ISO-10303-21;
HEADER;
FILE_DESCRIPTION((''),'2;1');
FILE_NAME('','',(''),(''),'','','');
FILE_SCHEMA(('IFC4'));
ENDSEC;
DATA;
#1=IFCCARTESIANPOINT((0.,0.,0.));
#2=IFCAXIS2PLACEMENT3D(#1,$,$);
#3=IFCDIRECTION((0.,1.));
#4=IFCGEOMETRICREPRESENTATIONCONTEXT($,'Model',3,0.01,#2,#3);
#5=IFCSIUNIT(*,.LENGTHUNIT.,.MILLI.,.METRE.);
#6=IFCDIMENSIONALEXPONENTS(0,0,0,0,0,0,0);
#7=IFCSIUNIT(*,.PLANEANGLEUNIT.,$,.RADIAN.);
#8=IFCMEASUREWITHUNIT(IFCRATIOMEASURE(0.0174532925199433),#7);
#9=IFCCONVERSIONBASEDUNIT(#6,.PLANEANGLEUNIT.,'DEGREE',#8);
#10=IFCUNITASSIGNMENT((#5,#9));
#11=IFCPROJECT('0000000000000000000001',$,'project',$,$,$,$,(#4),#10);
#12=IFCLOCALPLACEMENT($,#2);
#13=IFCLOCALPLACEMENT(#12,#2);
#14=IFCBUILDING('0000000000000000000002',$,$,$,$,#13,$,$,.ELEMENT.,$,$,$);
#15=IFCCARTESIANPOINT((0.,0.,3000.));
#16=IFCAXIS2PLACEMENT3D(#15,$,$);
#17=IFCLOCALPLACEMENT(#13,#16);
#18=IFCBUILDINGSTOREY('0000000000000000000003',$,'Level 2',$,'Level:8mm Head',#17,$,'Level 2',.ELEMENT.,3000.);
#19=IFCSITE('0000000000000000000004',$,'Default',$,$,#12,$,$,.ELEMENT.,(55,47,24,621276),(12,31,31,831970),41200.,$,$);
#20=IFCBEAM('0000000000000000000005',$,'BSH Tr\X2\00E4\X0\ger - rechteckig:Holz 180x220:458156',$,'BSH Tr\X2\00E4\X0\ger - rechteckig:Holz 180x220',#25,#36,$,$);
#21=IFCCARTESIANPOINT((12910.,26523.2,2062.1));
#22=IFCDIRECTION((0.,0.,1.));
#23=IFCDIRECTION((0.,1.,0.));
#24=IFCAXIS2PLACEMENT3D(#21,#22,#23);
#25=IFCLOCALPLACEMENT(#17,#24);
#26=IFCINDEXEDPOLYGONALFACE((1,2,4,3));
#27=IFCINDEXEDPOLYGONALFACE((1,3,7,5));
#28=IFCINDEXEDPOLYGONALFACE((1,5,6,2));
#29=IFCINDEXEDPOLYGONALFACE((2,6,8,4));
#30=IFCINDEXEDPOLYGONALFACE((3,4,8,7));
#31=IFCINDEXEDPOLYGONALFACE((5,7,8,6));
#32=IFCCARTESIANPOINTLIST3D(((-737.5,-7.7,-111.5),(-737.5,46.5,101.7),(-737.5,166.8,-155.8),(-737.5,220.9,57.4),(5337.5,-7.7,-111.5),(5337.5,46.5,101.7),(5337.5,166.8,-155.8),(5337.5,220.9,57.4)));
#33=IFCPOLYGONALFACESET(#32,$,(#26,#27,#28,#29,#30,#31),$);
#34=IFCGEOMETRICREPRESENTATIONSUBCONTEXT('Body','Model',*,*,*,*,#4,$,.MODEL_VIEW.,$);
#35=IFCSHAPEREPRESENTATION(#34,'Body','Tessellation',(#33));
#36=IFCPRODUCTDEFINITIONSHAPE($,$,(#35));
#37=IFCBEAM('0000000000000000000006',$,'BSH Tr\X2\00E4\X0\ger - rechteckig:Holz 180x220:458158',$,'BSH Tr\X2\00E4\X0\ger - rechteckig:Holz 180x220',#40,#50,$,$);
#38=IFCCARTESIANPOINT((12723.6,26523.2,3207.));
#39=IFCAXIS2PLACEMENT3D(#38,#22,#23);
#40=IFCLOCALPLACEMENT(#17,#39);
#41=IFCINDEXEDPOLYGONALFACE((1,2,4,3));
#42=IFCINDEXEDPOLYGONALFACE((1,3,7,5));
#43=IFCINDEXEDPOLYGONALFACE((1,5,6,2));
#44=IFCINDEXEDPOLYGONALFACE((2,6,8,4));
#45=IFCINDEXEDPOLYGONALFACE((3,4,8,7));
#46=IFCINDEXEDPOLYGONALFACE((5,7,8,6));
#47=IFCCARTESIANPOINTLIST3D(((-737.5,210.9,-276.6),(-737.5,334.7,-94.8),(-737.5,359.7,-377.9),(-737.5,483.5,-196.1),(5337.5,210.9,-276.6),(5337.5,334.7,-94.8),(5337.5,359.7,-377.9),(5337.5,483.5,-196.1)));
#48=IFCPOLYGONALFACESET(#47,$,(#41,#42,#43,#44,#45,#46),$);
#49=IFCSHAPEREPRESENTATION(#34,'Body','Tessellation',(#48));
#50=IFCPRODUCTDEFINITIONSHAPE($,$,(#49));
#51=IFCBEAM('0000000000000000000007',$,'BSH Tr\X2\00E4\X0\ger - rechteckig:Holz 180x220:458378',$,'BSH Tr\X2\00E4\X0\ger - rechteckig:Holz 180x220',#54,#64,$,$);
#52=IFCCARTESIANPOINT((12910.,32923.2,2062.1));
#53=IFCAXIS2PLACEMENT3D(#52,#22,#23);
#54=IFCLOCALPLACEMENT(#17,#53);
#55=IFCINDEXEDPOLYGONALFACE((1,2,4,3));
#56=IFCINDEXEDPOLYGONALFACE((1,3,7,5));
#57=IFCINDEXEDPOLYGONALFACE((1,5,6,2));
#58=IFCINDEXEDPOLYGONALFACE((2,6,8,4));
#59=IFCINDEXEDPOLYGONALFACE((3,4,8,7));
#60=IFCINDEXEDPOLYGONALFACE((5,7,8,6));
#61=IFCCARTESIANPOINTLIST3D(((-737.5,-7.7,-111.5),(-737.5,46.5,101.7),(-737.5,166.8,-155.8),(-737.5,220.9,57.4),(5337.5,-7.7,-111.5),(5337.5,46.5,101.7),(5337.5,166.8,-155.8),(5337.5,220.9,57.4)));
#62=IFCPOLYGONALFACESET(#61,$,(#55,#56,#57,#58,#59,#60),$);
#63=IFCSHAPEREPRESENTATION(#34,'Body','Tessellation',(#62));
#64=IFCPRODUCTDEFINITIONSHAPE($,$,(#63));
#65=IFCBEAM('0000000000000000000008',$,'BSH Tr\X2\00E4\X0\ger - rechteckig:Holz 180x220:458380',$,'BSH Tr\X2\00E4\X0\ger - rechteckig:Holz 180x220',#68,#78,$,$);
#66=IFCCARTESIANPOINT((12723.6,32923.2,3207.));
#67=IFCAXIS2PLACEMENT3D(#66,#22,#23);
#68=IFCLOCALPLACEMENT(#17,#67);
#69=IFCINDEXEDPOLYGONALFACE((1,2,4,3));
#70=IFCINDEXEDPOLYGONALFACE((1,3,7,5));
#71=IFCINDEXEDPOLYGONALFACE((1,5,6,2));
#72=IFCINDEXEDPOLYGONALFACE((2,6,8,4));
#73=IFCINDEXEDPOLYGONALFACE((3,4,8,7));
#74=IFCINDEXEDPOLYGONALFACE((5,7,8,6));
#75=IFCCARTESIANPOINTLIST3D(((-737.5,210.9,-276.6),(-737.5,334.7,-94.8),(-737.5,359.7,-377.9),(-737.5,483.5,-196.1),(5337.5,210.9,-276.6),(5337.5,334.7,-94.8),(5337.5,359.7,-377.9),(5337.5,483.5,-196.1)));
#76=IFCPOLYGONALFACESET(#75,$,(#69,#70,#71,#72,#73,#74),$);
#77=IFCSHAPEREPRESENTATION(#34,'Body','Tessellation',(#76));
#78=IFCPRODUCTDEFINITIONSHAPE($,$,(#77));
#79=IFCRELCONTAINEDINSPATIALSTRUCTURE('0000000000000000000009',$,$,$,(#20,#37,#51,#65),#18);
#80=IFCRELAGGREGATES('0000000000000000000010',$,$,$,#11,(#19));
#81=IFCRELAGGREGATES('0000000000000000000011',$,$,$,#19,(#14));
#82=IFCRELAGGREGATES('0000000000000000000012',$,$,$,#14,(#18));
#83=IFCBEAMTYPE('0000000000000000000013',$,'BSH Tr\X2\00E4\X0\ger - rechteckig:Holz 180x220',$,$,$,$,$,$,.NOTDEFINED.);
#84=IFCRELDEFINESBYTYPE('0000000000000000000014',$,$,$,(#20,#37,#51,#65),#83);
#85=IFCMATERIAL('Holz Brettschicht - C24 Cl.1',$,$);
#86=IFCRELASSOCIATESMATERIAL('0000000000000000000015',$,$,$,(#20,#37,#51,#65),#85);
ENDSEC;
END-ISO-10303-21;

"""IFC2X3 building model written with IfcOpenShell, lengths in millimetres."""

from ifc_helpers import new_model, entity, si_unit, converted_unit, direction, frame, frame_2d, origin, place, context, subcontext, project, spatial, rectangle, extrude, material, type_object, element, save


model = new_model("IFC2X3")

# Units and contexts
model_context = context("Model", 3, precision=0.01, world=origin(), true_north=direction((0.0, 1.0)))
body_context = subcontext(model_context, "Body", "Model", "MODEL_VIEW")
ifc_project = project(units=[si_unit("LENGTHUNIT", "METRE", prefix="MILLI"), converted_unit("PLANEANGLEUNIT", "DEGREE", entity("IfcRatioMeasure", 0.0174532925199433), si_unit("PLANEANGLEUNIT", "RADIAN"), dimensions=[0, 0, 0, 0, 0, 0, 0])], contexts=[model_context])

# Site, building, storey
site_placement = place(None, origin())
site = spatial("IfcSite", under=ifc_project, at=site_placement, Name="Default", CompositionType="ELEMENT", RefLatitude=(55, 47, 24, 621276), RefLongitude=(12, 31, 31, 831970), RefElevation=41200.0)
building_placement = place(site_placement, origin())
building = spatial("IfcBuilding", under=site, at=building_placement, CompositionType="ELEMENT")
storey_placement = place(building_placement, frame((0.0, 0.0, 3000.0)))
storey = spatial("IfcBuildingStorey", under=building, at=storey_placement, Name="Level 2", ObjectType="Level:8mm Head", LongName="Level 2", CompositionType="ELEMENT", Elevation=3000.0)

# Beams
ifc_material_1 = material(Name="Holz Brettschicht - C24 Cl.1")
beam_type_1 = type_object("IfcBeamType", Name="BSH Träger - rechteckig:Holz 180x220", PredefinedType="NOTDEFINED")
beam_1_placement = place(storey_placement, frame((12910.0, 26523.2, 2062.1), z_axis=(0.0, 0.0, 1.0), x_axis=(0.0, 1.0, 0.0)))
element("IfcBeam", 1, at=beam_1_placement, inside=storey, type_object=beam_type_1, material=ifc_material_1, Name="BSH Träger - rechteckig:Holz 180x220:458156", ObjectType="BSH Träger - rechteckig:Holz 180x220", context=body_context, shape_type="SweptSolid", body=[
    extrude(rectangle(XDim=220.0, YDim=180.0, at=frame_2d((0.0, 0.0), x_axis=(1.0, 0.0))), frame((-737.5, 106.6, -27.1), z_axis=(1.0, 0.0, 0.0), x_axis=(0.0, 0.246135, 0.969236)), (0.0, 0.0, 1.0), 6075.0),
])
beam_2_placement = place(storey_placement, frame((12723.6, 26523.2, 3207.0), z_axis=(0.0, 0.0, 1.0), x_axis=(0.0, 1.0, 0.0)))
element("IfcBeam", 2, at=beam_2_placement, inside=storey, type_object=beam_type_1, material=ifc_material_1, Name="BSH Träger - rechteckig:Holz 180x220:458158", ObjectType="BSH Träger - rechteckig:Holz 180x220", context=body_context, shape_type="SweptSolid", body=[
    extrude(rectangle(XDim=220.0, YDim=180.0, at=frame_2d((0.0, 0.0), x_axis=(1.0, 0.0))), frame((-737.5, 347.2, -236.4), z_axis=(1.0, 0.0, 0.0), x_axis=(0.0, 0.562789, 0.826601)), (0.0, 0.0, 1.0), 6075.0),
])
beam_3_placement = place(storey_placement, frame((12910.0, 32923.2, 2062.1), z_axis=(0.0, 0.0, 1.0), x_axis=(0.0, 1.0, 0.0)))
element("IfcBeam", 3, at=beam_3_placement, inside=storey, type_object=beam_type_1, material=ifc_material_1, Name="BSH Träger - rechteckig:Holz 180x220:458378", ObjectType="BSH Träger - rechteckig:Holz 180x220", context=body_context, shape_type="SweptSolid", body=[
    extrude(rectangle(XDim=220.0, YDim=180.0, at=frame_2d((0.0, 0.0), x_axis=(1.0, 0.0))), frame((-737.5, 106.6, -27.1), z_axis=(1.0, 0.0, 0.0), x_axis=(0.0, 0.246135, 0.969236)), (0.0, 0.0, 1.0), 6075.0),
])
beam_4_placement = place(storey_placement, frame((12723.6, 32923.2, 3207.0), z_axis=(0.0, 0.0, 1.0), x_axis=(0.0, 1.0, 0.0)))
element("IfcBeam", 4, at=beam_4_placement, inside=storey, type_object=beam_type_1, material=ifc_material_1, Name="BSH Träger - rechteckig:Holz 180x220:458380", ObjectType="BSH Träger - rechteckig:Holz 180x220", context=body_context, shape_type="SweptSolid", body=[
    extrude(rectangle(XDim=220.0, YDim=180.0, at=frame_2d((0.0, 0.0), x_axis=(1.0, 0.0))), frame((-737.5, 347.2, -236.4), z_axis=(1.0, 0.0, 0.0), x_axis=(0.0, 0.562789, 0.826601)), (0.0, 0.0, 1.0), 6075.0),
])

save(model, "model.ifc")
